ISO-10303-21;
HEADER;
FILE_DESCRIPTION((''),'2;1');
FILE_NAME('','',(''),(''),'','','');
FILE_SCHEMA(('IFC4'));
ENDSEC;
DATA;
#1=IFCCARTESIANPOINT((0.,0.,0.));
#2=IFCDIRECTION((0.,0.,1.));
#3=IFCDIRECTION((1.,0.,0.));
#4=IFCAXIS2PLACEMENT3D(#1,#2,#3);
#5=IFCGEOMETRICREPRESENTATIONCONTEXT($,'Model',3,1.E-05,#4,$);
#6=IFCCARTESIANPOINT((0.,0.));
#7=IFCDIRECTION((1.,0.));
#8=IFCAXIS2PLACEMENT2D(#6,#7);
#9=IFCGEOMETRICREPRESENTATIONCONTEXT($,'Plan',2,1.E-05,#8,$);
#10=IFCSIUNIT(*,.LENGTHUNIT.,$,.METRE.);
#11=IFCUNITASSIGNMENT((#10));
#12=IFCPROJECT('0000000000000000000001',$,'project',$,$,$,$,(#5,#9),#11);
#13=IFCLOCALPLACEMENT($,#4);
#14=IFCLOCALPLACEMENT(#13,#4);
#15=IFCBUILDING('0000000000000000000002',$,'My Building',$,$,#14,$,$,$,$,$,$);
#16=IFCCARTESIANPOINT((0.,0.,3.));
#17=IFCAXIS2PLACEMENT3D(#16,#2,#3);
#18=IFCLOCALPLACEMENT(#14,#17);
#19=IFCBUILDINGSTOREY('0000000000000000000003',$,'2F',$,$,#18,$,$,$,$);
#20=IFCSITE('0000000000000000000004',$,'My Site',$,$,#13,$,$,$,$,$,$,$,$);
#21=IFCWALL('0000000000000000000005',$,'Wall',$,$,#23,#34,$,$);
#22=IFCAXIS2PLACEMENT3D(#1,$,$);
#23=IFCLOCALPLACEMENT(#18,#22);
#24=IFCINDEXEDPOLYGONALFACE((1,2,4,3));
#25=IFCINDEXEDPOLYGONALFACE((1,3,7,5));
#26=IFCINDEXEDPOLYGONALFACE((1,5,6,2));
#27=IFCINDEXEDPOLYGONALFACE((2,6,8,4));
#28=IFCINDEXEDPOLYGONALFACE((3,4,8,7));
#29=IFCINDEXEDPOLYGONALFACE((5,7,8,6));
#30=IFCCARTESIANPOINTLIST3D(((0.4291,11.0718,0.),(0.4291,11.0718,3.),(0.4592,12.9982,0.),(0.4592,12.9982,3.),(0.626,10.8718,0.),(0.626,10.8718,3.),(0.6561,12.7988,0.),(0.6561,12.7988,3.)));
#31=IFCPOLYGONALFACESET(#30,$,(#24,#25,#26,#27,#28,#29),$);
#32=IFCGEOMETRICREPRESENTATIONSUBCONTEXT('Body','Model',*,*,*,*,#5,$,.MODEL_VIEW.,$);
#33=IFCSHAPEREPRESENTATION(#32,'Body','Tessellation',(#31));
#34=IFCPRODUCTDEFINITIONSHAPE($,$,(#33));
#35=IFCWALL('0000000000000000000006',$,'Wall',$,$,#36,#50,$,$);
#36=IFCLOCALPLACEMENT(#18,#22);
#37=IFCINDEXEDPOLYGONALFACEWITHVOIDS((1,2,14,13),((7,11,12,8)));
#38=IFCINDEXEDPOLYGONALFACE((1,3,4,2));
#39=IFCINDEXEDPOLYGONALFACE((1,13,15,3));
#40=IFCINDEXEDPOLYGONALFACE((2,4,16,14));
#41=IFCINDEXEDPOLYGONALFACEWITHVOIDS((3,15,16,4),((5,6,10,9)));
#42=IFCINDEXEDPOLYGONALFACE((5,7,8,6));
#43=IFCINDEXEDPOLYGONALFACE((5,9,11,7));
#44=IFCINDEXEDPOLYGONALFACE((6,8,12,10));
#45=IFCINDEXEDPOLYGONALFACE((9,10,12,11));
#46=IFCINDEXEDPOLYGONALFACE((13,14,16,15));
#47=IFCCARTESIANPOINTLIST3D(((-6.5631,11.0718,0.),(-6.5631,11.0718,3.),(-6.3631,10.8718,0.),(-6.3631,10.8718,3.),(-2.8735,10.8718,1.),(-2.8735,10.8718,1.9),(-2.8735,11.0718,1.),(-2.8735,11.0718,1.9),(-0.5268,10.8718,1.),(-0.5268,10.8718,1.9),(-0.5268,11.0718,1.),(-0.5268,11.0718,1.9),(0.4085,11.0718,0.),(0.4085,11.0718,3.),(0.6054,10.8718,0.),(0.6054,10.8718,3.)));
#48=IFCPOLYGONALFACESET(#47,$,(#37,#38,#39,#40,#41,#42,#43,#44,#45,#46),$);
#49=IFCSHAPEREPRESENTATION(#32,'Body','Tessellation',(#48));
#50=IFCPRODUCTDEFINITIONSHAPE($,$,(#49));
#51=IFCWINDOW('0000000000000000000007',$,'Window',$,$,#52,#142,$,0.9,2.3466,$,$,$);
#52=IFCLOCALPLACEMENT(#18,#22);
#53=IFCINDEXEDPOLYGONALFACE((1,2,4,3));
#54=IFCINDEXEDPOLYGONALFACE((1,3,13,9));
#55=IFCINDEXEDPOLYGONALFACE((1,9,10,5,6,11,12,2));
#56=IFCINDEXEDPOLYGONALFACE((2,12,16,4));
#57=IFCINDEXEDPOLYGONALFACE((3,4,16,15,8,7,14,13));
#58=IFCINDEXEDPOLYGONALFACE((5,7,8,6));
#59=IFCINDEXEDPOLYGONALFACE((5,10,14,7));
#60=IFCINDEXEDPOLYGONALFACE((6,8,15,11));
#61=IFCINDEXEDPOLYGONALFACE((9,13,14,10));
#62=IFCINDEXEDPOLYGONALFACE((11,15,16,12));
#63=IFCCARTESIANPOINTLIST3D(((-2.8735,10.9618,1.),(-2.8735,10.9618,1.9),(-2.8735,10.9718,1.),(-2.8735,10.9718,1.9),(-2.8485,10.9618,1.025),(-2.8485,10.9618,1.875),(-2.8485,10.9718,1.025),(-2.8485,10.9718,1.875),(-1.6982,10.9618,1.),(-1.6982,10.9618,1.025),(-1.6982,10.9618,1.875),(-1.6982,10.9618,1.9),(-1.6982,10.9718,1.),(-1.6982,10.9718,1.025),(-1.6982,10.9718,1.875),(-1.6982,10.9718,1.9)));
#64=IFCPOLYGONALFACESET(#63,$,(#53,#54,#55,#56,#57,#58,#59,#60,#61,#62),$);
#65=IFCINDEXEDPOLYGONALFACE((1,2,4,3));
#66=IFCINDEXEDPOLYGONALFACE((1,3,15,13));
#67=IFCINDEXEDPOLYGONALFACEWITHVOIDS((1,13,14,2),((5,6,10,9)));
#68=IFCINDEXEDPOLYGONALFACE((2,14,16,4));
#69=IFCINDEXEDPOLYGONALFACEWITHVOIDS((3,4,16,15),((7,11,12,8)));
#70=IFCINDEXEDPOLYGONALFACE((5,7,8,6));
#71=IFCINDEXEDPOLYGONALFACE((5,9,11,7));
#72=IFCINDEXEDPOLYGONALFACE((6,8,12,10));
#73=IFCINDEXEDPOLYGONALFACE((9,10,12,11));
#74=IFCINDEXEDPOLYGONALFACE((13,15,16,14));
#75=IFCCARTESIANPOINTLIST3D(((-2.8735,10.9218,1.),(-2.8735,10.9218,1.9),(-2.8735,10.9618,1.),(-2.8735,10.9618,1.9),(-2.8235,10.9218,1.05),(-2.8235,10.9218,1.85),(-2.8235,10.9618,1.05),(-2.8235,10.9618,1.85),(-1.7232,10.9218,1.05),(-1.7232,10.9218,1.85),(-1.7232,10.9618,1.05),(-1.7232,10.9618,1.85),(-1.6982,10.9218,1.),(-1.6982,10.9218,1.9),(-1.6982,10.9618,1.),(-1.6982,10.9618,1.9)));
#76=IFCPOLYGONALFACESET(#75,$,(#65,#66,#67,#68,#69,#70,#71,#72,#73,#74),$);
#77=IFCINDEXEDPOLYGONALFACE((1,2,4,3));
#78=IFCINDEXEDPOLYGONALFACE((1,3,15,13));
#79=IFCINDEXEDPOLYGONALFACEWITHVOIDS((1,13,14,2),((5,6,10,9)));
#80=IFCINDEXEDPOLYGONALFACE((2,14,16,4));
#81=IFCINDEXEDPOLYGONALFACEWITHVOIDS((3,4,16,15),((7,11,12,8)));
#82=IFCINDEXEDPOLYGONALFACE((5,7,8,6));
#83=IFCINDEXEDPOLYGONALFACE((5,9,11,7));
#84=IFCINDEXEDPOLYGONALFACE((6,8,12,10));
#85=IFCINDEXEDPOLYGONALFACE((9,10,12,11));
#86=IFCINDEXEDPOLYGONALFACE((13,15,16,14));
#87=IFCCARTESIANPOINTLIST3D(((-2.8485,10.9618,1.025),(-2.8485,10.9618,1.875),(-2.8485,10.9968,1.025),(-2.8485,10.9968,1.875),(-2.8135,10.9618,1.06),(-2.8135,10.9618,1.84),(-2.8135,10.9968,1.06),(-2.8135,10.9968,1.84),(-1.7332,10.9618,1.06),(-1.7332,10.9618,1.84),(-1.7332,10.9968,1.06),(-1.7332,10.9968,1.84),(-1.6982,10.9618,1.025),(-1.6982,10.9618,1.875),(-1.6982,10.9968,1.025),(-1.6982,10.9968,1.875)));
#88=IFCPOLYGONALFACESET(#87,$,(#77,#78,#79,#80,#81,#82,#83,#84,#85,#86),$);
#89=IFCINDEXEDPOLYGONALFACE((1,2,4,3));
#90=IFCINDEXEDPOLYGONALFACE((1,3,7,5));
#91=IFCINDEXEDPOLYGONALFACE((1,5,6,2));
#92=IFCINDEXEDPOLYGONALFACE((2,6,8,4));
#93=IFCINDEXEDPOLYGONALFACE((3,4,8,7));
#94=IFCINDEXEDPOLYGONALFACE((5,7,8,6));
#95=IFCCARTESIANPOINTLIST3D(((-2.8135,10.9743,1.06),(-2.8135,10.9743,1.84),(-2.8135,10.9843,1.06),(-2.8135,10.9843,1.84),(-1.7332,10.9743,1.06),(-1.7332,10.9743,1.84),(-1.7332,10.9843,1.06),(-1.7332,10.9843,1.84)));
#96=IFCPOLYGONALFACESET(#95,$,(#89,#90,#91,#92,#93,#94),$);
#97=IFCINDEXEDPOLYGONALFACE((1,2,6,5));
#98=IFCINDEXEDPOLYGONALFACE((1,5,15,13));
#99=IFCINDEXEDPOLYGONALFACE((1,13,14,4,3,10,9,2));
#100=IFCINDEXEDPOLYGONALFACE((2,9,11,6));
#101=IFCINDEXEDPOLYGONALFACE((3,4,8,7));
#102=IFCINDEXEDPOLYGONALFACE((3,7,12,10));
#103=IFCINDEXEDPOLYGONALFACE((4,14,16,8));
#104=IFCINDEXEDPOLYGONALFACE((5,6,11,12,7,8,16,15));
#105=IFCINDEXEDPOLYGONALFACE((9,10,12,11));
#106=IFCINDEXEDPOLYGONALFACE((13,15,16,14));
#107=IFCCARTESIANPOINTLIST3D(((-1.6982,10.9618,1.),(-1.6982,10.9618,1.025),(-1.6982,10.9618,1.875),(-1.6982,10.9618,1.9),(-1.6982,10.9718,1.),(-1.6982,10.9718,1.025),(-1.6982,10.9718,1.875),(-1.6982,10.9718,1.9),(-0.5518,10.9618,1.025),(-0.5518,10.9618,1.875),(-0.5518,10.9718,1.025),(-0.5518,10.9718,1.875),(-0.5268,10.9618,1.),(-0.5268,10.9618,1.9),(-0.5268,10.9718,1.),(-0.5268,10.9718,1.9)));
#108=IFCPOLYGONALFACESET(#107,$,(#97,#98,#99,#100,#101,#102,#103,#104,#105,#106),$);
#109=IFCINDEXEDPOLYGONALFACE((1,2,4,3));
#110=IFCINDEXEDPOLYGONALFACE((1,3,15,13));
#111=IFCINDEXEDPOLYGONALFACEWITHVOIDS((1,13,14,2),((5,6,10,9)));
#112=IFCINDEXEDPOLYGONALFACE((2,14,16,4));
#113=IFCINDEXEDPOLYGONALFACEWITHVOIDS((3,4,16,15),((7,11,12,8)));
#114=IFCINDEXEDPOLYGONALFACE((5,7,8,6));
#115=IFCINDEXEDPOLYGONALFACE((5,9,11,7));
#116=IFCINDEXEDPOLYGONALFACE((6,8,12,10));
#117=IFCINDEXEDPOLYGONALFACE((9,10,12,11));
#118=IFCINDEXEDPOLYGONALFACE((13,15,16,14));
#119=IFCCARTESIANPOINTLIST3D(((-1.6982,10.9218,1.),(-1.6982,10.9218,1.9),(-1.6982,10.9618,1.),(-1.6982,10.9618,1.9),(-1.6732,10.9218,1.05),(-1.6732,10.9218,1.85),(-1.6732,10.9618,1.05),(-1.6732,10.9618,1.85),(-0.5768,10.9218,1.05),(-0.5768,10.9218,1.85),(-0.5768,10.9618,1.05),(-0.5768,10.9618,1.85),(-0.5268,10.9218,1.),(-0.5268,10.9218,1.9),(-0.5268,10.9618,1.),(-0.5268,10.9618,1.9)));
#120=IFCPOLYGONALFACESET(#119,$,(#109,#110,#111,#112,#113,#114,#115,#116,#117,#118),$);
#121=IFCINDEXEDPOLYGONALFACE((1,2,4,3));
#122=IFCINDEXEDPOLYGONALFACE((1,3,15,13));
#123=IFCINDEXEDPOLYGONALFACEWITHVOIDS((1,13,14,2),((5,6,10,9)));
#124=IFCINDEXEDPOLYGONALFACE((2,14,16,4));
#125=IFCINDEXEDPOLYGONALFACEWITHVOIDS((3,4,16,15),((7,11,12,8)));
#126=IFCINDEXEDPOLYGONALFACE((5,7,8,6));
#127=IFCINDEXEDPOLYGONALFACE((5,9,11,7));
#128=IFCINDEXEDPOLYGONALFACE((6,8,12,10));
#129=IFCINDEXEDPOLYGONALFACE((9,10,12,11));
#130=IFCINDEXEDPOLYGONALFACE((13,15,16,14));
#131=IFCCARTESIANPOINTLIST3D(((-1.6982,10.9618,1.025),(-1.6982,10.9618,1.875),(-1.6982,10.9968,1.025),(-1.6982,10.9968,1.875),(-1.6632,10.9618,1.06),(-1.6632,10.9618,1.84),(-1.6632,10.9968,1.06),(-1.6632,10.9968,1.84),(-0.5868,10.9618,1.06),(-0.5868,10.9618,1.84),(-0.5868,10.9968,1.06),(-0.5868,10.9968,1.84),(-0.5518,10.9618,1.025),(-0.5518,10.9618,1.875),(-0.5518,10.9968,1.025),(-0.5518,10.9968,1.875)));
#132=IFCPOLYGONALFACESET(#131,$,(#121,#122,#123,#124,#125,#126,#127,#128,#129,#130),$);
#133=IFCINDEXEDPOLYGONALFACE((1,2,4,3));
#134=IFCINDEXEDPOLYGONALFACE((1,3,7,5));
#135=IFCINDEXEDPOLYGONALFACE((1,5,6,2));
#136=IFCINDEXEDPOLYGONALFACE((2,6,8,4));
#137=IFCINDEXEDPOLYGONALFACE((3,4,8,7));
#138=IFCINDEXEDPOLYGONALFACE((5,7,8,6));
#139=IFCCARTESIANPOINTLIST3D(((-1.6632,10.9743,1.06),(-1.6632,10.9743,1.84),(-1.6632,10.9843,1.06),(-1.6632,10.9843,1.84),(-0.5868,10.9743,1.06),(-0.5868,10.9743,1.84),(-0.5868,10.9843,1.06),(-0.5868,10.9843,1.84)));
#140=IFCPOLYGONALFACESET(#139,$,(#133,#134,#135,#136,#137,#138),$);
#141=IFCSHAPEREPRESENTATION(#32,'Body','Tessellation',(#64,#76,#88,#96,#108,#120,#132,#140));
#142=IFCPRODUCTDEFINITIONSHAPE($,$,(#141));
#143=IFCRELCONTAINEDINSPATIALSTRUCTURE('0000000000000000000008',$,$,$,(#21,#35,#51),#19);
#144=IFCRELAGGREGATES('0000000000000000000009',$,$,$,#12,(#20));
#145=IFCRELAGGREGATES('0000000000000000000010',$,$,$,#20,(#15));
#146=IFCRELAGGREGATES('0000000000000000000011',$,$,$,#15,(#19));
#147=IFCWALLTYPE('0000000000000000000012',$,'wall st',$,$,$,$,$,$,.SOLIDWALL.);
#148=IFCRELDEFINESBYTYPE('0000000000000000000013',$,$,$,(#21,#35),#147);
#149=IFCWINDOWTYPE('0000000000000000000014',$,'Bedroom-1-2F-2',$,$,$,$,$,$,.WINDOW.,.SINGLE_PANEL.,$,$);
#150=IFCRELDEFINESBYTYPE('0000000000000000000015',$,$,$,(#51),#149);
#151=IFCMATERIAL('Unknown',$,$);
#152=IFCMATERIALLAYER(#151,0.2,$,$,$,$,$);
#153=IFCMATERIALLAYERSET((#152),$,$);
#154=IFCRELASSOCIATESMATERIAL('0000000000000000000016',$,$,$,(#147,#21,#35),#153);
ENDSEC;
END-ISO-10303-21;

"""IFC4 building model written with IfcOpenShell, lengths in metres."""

from ifc_helpers import new_model, entity, si_unit, frame, origin_with_axes, origin_2d_with_axis, place, context, subcontext, project, spatial, line, indexed_curve, outline, extrude, shape, source, transform, mapped, material, layer, layer_set, layer_usage, type_object, type_shapes, element, fill, save


model = new_model("IFC4")

# Units and contexts
model_context = context("Model", 3, precision=1e-05, world=origin_with_axes())
plan_context = context("Plan", 2, precision=1e-05, world=origin_2d_with_axis())
body_context_1 = subcontext(model_context, "Body", "Model", "MODEL_VIEW")
body_context_2 = subcontext(plan_context, "Body", "Plan", "PLAN_VIEW")
ifc_project = project(units=[si_unit("LENGTHUNIT", "METRE")], contexts=[model_context, plan_context])

# Site, building, storey
site_placement = place(None, origin_with_axes())
site = spatial("IfcSite", under=ifc_project, at=site_placement, Name="My Site")
building_placement = place(site_placement, origin_with_axes())
building = spatial("IfcBuilding", under=site, at=building_placement, Name="My Building")
storey_placement = place(building_placement, frame((0.0, 0.0, 3.0), z_axis=(0.0, 0.0, 1.0), x_axis=(1.0, 0.0, 0.0)))
storey = spatial("IfcBuildingStorey", under=building, at=storey_placement, Name="2F")

# Shared definitions
ifc_material = material(Name="Unknown")

# Shared definitions
ifc_layer_1 = layer(ifc_material, 0.2)
ifc_layer_set_1 = layer_set([ifc_layer_1])
wall_type_1 = type_object("IfcWallType", Name="wall st", PredefinedType="SOLIDWALL", material=ifc_layer_set_1)

# Wall
ifc_layer_usage_1 = layer_usage(ifc_layer_set_1, "AXIS2", "POSITIVE", 0.0)
wall_1_placement = place(storey_placement, frame((0.4592, 12.9982, 0.0), z_axis=(0.0, 0.0, 1.0), x_axis=(-0.015623, -0.999878, 0.0)))
element("IfcWall", 1, at=wall_1_placement, inside=storey, type_object=wall_type_1, material=ifc_layer_usage_1, Name="Wall", context=body_context_1, shape_type="SweptSolid", body=[
    extrude(outline(indexed_curve([(0.0, 0.0), (0.1962, 0.2), (2.1235, 0.2), (1.9266, 0.0)], segments=[line(1, 2, 3, 4, 1)])), origin_with_axes(), (0.0, 0.0, 1.0), 3.0),
])

# Wall, opening, window
ifc_layer_usage_2 = layer_usage(ifc_layer_set_1, "AXIS2", "POSITIVE", 0.0)
wall_2_placement = place(storey_placement, frame((0.4085, 11.0718, 0.0), z_axis=(0.0, 0.0, 1.0), x_axis=(-1.0, 0.0, 0.0)))
wall_2 = element("IfcWall", 2, at=wall_2_placement, inside=storey, type_object=wall_type_1, material=ifc_layer_usage_2, Name="Wall", context=body_context_1, shape_type="SweptSolid", body=[
    extrude(outline(indexed_curve([(0.0, 0.0), (-0.1969, 0.2), (6.7716, 0.2), (6.9715, 0.0)], segments=[line(1, 2, 3, 4, 1)])), origin_with_axes(), (0.0, 0.0, 1.0), 3.0),
])
shared_shape_1 = source(origin_with_axes(), body_context_1, "Body", "SweptSolid", [
    extrude(outline(indexed_curve([(0.0, 0.0), (2.3466, 0.0), (2.3466, 0.9), (0.0, 0.9)], segments=[line(1, 2, 3, 4, 1)])), frame((0.0, -0.6, 0.0), z_axis=(0.0, -1.0, 0.0), x_axis=(1.0, 0.0, 0.0)), (0.0, 0.0, -1.0), 1.2),
])
opening_1_placement = place(wall_2_placement, frame((3.2819, 0.2, 1.0), z_axis=(0.0, 0.0, 1.0), x_axis=(-1.0, 0.0, 0.0)))
opening_1 = element("IfcOpeningElement", 3, at=opening_1_placement, cuts=wall_2, PredefinedType="OPENING", context=body_context_1, shape_type="MappedRepresentation", body=[
    mapped(shared_shape_1, transform((0.0, 0.0, 0.0), x_axis=(1.0, 0.0, 0.0), y_axis=(0.0, 1.0, 0.0), z_axis=(0.0, 0.0, 1.0), scale=1.0)),
])
window_type_1 = type_object("IfcWindowType", Name="Bedroom-1-2F-2", PartitioningType="SINGLE_PANEL", PredefinedType="WINDOW")
shared_shape_2 = source(origin_with_axes(), body_context_1, "Body", "SweptSolid", [
    extrude(outline(indexed_curve([(1.1752, 0.0), (0.0, 0.0), (0.0, 0.9), (1.1752, 0.9), (1.1752, 0.875), (0.025, 0.875), (0.025, 0.025), (1.1752, 0.025)], segments=[line(1, 2, 3, 4, 5, 6, 7, 8, 1)])), frame((0.0, 0.09, 0.0), z_axis=(0.0, -1.0, 0.0), x_axis=(1.0, 0.0, 0.0)), (0.0, 0.0, -1.0), 0.01),
    extrude(outline(indexed_curve([(0.0, 0.0), (1.1752, 0.0), (1.1752, 0.9), (0.0, 0.9)], segments=[line(1, 2, 3, 4, 1)]), holes=[indexed_curve([(0.05, 0.05), (1.1502, 0.05), (1.1502, 0.85), (0.05, 0.85)], segments=[line(1, 2, 3, 4, 1)])]), frame((0.0, 0.05, 0.0), z_axis=(0.0, -1.0, 0.0), x_axis=(1.0, 0.0, 0.0)), (0.0, 0.0, -1.0), 0.04),
    extrude(outline(indexed_curve([(0.0, 0.0), (1.1502, 0.0), (1.1502, 0.85), (0.0, 0.85)], segments=[line(1, 2, 3, 4, 1)]), holes=[indexed_curve([(0.035, 0.035), (1.1152, 0.035), (1.1152, 0.815), (0.035, 0.815)], segments=[line(1, 2, 3, 4, 1)])]), frame((0.025, 0.09, 0.025), z_axis=(0.0, -1.0, 0.0), x_axis=(1.0, 0.0, 0.0)), (0.0, 0.0, -1.0), 0.035),
    extrude(outline(indexed_curve([(0.035, 0.035), (1.1152, 0.035), (1.1152, 0.815), (0.035, 0.815)], segments=[line(1, 2, 3, 4, 1)])), frame((0.025, 0.1025, 0.025), z_axis=(0.0, -1.0, 0.0), x_axis=(1.0, 0.0, 0.0)), (0.0, 0.0, -1.0), 0.01),
    extrude(outline(indexed_curve([(0.0, 0.9), (1.1714, 0.9), (1.1714, 0.0), (0.0, 0.0), (0.0, 0.025), (1.1464, 0.025), (1.1464, 0.875), (0.0, 0.875)], segments=[line(1, 2, 3, 4, 5, 6, 7, 8, 1)])), frame((1.1752, 0.09, 0.0), z_axis=(0.0, -1.0, 0.0), x_axis=(1.0, 0.0, 0.0)), (0.0, 0.0, -1.0), 0.01),
    extrude(outline(indexed_curve([(0.0, 0.0), (1.1714, 0.0), (1.1714, 0.9), (0.0, 0.9)], segments=[line(1, 2, 3, 4, 1)]), holes=[indexed_curve([(0.025, 0.05), (1.1214, 0.05), (1.1214, 0.85), (0.025, 0.85)], segments=[line(1, 2, 3, 4, 1)])]), frame((1.1752, 0.05, 0.0), z_axis=(0.0, -1.0, 0.0), x_axis=(1.0, 0.0, 0.0)), (0.0, 0.0, -1.0), 0.04),
    extrude(outline(indexed_curve([(0.0, 0.0), (1.1464, 0.0), (1.1464, 0.85), (0.0, 0.85)], segments=[line(1, 2, 3, 4, 1)]), holes=[indexed_curve([(0.035, 0.035), (1.1114, 0.035), (1.1114, 0.815), (0.035, 0.815)], segments=[line(1, 2, 3, 4, 1)])]), frame((1.1752, 0.09, 0.025), z_axis=(0.0, -1.0, 0.0), x_axis=(1.0, 0.0, 0.0)), (0.0, 0.0, -1.0), 0.035),
    extrude(outline(indexed_curve([(0.035, 0.035), (1.1114, 0.035), (1.1114, 0.815), (0.035, 0.815)], segments=[line(1, 2, 3, 4, 1)])), frame((1.1752, 0.1025, 0.025), z_axis=(0.0, -1.0, 0.0), x_axis=(1.0, 0.0, 0.0)), (0.0, 0.0, -1.0), 0.01),
])
shared_shape_3 = source(origin_with_axes(), body_context_2, "Body", "Curve2D", [
    entity("IfcIndexedPolyCurve", entity("IfcCartesianPointList2D", [[0.05, 0.05], [1.1502, 0.05]])),
    entity("IfcIndexedPolyCurve", entity("IfcCartesianPointList2D", [[0.0, 0.1], [0.025, 0.1], [0.025, 0.09], [0.05, 0.09], [0.05, 0.05], [0.0, 0.05]]), [entity("IfcLineIndex", [1, 2, 3, 4, 5, 6, 1])]),
    entity("IfcIndexedPolyCurve", entity("IfcCartesianPointList2D", [[1.1752, 0.1], [1.1752, 0.1], [1.1752, 0.09], [1.1502, 0.09], [1.1502, 0.05], [1.1752, 0.05]])),
    entity("IfcIndexedPolyCurve", entity("IfcCartesianPointList2D", [[0.025, 0.09], [0.06, 0.09], [0.06, 0.125], [0.025, 0.125]]), [entity("IfcLineIndex", [1, 2, 3, 4, 1])]),
    entity("IfcIndexedPolyCurve", entity("IfcCartesianPointList2D", [[1.1752, 0.09], [1.1402, 0.09], [1.1402, 0.125], [1.1752, 0.125]]), [entity("IfcLineIndex", [1, 2, 3, 4, 1])]),
    entity("IfcIndexedPolyCurve", entity("IfcCartesianPointList2D", [[0.06, 0.09], [1.1402, 0.09]])),
    entity("IfcIndexedPolyCurve", entity("IfcCartesianPointList2D", [[0.06, 0.125], [1.1402, 0.125]])),
    entity("IfcIndexedPolyCurve", entity("IfcCartesianPointList2D", [[0.06, 0.1075], [1.1402, 0.1075]])),
    entity("IfcIndexedPolyCurve", entity("IfcCartesianPointList2D", [[1.2002, 0.05], [2.2966, 0.05]])),
    entity("IfcIndexedPolyCurve", entity("IfcCartesianPointList2D", [[1.1752, 0.1], [1.1752, 0.1], [1.1752, 0.09], [1.2002, 0.09], [1.2002, 0.05], [1.1752, 0.05]])),
    entity("IfcIndexedPolyCurve", entity("IfcCartesianPointList2D", [[2.3466, 0.1], [2.3216, 0.1], [2.3216, 0.09], [2.2966, 0.09], [2.2966, 0.05], [2.3466, 0.05]]), [entity("IfcLineIndex", [1, 2, 3, 4, 5, 6, 1])]),
    entity("IfcIndexedPolyCurve", entity("IfcCartesianPointList2D", [[1.1752, 0.09], [1.2102, 0.09], [1.2102, 0.125], [1.1752, 0.125]]), [entity("IfcLineIndex", [1, 2, 3, 4, 1])]),
    entity("IfcIndexedPolyCurve", entity("IfcCartesianPointList2D", [[2.3216, 0.09], [2.2866, 0.09], [2.2866, 0.125], [2.3216, 0.125]]), [entity("IfcLineIndex", [1, 2, 3, 4, 1])]),
    entity("IfcIndexedPolyCurve", entity("IfcCartesianPointList2D", [[1.2102, 0.09], [2.2866, 0.09]])),
    entity("IfcIndexedPolyCurve", entity("IfcCartesianPointList2D", [[1.2102, 0.125], [2.2866, 0.125]])),
    entity("IfcIndexedPolyCurve", entity("IfcCartesianPointList2D", [[1.2102, 0.1075], [2.2866, 0.1075]])),
])
type_shapes(window_type_1, [shared_shape_2, shared_shape_3])
window_1_placement = place(opening_1_placement, frame((0.0, 0.0, 0.0), z_axis=(0.0, 0.0, 1.0), x_axis=(1.0, 0.0, 0.0)))
window_1 = element("IfcWindow", 4, at=window_1_placement, inside=storey, type_object=window_type_1, Name="Window", OverallHeight=0.9, OverallWidth=2.3466, shapes=[
    shape(body_context_1, "Body", "MappedRepresentation", [mapped(shared_shape_2, transform((0.0, 0.0, 0.0), x_axis=(1.0, 0.0, 0.0), y_axis=(0.0, 1.0, 0.0), z_axis=(0.0, 0.0, 1.0), scale=1.0))]),
    shape(body_context_2, "Body", "MappedRepresentation", [mapped(shared_shape_3, transform((0.0, 0.0, 0.0), x_axis=(1.0, 0.0, 0.0), y_axis=(0.0, 1.0, 0.0), z_axis=(0.0, 0.0, 1.0), scale=1.0))]),
])
fill(opening_1, window_1)

save(model, "model.ifc")
